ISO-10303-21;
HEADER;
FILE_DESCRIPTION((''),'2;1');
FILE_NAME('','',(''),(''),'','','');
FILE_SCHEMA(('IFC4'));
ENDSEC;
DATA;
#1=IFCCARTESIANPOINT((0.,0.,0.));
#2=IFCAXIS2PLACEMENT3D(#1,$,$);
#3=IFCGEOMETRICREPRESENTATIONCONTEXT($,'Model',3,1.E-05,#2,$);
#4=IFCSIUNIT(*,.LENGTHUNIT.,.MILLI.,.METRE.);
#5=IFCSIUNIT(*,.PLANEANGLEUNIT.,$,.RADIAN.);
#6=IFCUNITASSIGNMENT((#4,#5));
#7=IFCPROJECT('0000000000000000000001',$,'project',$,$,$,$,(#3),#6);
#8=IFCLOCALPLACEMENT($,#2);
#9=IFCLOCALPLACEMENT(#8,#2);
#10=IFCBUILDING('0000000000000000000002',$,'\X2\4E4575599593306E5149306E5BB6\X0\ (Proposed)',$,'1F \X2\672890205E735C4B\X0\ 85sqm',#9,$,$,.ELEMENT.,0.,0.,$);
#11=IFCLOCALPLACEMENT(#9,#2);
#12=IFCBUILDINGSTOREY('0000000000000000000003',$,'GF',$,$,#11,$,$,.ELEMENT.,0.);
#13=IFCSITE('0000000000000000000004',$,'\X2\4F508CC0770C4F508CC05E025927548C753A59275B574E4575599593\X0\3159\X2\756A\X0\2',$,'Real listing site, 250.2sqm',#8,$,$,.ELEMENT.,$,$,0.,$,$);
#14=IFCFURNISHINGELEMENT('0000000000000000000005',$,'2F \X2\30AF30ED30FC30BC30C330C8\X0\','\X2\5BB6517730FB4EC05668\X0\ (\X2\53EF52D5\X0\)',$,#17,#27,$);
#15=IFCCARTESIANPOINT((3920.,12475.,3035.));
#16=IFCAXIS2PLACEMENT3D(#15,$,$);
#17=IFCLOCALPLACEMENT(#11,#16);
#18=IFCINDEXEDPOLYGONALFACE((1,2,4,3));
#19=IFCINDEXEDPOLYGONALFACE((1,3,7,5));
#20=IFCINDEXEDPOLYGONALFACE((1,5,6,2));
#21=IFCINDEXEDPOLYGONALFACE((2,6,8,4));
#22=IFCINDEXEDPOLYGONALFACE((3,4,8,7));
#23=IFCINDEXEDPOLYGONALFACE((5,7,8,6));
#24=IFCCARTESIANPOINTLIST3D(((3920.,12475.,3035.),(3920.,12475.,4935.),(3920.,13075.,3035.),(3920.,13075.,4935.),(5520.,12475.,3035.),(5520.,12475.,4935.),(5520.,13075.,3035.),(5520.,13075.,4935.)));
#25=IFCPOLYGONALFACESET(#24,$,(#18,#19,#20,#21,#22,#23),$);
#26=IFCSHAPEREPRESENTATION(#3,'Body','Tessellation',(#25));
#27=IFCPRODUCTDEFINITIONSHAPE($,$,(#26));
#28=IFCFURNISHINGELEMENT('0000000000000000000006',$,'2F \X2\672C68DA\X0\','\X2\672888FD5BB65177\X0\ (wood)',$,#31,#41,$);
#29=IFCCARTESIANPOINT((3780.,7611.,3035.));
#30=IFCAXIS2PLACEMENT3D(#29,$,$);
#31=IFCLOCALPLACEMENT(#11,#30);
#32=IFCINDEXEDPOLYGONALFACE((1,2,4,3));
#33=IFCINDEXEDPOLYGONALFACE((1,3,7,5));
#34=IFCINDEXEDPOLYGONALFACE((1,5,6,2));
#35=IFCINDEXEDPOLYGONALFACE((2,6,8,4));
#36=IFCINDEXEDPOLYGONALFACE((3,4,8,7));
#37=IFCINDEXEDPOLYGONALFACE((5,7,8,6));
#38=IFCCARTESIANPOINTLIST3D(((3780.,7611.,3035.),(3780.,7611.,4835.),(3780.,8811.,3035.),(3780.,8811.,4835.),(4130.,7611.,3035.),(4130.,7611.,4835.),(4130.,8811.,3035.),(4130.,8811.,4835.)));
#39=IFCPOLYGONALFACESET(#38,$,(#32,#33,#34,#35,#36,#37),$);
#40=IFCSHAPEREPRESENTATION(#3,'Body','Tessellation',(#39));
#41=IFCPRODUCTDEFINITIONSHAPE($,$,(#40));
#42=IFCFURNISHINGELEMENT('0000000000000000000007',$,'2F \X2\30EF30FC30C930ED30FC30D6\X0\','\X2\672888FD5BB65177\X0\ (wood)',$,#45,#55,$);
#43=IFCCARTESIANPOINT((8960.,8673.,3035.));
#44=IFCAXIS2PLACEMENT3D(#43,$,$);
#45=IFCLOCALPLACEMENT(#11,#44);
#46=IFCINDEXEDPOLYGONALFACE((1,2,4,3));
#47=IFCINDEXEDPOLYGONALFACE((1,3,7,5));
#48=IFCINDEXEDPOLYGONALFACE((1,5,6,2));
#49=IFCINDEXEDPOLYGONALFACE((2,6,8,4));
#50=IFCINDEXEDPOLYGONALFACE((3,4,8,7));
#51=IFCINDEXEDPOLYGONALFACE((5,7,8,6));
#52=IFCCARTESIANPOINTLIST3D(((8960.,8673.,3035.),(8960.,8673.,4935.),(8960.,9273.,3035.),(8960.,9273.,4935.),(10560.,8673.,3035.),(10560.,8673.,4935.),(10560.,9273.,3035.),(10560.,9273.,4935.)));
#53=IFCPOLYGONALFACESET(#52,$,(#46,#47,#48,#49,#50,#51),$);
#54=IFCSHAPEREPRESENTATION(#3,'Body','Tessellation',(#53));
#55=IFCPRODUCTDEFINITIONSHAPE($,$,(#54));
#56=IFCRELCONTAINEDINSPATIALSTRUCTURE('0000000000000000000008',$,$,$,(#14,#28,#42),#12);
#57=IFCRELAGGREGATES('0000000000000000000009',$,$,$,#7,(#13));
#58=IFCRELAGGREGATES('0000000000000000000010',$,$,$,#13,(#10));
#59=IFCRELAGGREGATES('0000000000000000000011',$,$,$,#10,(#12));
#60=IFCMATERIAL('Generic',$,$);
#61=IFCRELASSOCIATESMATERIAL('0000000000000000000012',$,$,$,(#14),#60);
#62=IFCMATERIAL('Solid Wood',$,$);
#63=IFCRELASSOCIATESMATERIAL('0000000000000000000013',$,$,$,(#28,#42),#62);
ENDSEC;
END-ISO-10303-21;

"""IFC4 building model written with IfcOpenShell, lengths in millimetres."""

from ifc_helpers import new_model, si_unit, frame, frame_2d, origin, place, context, project, spatial, rectangle, extrude, material, element, save


model = new_model("IFC4")

# Units and contexts
model_context = context("Model", 3, precision=1e-05, world=origin())
ifc_project = project(units=[si_unit("LENGTHUNIT", "METRE", prefix="MILLI"), si_unit("PLANEANGLEUNIT", "RADIAN")], contexts=[model_context])

# Site, building, storey
site_placement = place(None, origin())
site = spatial("IfcSite", under=ifc_project, at=site_placement, Name="佐賀県佐賀市大和町大字久留間3159番2", ObjectType="Real listing site, 250.2sqm", CompositionType="ELEMENT", RefElevation=0.0)
building_placement = place(site_placement, origin())
building = spatial("IfcBuilding", under=site, at=building_placement, Name="久留間の光の家 (Proposed)", ObjectType="1F 木造平屋 85sqm", CompositionType="ELEMENT", ElevationOfRefHeight=0.0, ElevationOfTerrain=0.0)
storey_placement = place(building_placement, origin())
storey = spatial("IfcBuildingStorey", under=building, at=storey_placement, Name="GF", CompositionType="ELEMENT", Elevation=0.0)

# Shared definitions
ifc_material_1 = material(Name="Solid Wood")

# Shared definitions
ifc_material_2 = material(Name="Generic")

# Furnishing elements
furnishing_1_placement = place(storey_placement, frame((3920.0, 12475.0, 3035.0)))
element("IfcFurnishingElement", 1, at=furnishing_1_placement, inside=storey, material=ifc_material_2, Name="2F クローゼット", Description="家具・什器 (可動)", context=model_context, shape_type="SweptSolid", body=[
    extrude(rectangle(XDim=1600.0, YDim=600.0, at=frame_2d((800.0, 300.0))), frame((3920.0, 12475.0, 3035.0)), (0.0, 0.0, 1.0), 1900.0),
])
furnishing_2_placement = place(storey_placement, frame((3780.0, 7611.0, 3035.0)))
element("IfcFurnishingElement", 2, at=furnishing_2_placement, inside=storey, material=ifc_material_1, Name="2F 本棚", Description="木製家具 (wood)", context=model_context, shape_type="SweptSolid", body=[
    extrude(rectangle(XDim=350.0, YDim=1200.0, at=frame_2d((175.0, 600.0))), frame((3780.0, 7611.0, 3035.0)), (0.0, 0.0, 1.0), 1800.0),
])
furnishing_3_placement = place(storey_placement, frame((8960.0, 8673.0, 3035.0)))
element("IfcFurnishingElement", 3, at=furnishing_3_placement, inside=storey, material=ifc_material_1, Name="2F ワードローブ", Description="木製家具 (wood)", context=model_context, shape_type="SweptSolid", body=[
    extrude(rectangle(XDim=1600.0, YDim=600.0, at=frame_2d((800.0, 300.0))), frame((8960.0, 8673.0, 3035.0)), (0.0, 0.0, 1.0), 1900.0),
])

save(model, "model.ifc")
